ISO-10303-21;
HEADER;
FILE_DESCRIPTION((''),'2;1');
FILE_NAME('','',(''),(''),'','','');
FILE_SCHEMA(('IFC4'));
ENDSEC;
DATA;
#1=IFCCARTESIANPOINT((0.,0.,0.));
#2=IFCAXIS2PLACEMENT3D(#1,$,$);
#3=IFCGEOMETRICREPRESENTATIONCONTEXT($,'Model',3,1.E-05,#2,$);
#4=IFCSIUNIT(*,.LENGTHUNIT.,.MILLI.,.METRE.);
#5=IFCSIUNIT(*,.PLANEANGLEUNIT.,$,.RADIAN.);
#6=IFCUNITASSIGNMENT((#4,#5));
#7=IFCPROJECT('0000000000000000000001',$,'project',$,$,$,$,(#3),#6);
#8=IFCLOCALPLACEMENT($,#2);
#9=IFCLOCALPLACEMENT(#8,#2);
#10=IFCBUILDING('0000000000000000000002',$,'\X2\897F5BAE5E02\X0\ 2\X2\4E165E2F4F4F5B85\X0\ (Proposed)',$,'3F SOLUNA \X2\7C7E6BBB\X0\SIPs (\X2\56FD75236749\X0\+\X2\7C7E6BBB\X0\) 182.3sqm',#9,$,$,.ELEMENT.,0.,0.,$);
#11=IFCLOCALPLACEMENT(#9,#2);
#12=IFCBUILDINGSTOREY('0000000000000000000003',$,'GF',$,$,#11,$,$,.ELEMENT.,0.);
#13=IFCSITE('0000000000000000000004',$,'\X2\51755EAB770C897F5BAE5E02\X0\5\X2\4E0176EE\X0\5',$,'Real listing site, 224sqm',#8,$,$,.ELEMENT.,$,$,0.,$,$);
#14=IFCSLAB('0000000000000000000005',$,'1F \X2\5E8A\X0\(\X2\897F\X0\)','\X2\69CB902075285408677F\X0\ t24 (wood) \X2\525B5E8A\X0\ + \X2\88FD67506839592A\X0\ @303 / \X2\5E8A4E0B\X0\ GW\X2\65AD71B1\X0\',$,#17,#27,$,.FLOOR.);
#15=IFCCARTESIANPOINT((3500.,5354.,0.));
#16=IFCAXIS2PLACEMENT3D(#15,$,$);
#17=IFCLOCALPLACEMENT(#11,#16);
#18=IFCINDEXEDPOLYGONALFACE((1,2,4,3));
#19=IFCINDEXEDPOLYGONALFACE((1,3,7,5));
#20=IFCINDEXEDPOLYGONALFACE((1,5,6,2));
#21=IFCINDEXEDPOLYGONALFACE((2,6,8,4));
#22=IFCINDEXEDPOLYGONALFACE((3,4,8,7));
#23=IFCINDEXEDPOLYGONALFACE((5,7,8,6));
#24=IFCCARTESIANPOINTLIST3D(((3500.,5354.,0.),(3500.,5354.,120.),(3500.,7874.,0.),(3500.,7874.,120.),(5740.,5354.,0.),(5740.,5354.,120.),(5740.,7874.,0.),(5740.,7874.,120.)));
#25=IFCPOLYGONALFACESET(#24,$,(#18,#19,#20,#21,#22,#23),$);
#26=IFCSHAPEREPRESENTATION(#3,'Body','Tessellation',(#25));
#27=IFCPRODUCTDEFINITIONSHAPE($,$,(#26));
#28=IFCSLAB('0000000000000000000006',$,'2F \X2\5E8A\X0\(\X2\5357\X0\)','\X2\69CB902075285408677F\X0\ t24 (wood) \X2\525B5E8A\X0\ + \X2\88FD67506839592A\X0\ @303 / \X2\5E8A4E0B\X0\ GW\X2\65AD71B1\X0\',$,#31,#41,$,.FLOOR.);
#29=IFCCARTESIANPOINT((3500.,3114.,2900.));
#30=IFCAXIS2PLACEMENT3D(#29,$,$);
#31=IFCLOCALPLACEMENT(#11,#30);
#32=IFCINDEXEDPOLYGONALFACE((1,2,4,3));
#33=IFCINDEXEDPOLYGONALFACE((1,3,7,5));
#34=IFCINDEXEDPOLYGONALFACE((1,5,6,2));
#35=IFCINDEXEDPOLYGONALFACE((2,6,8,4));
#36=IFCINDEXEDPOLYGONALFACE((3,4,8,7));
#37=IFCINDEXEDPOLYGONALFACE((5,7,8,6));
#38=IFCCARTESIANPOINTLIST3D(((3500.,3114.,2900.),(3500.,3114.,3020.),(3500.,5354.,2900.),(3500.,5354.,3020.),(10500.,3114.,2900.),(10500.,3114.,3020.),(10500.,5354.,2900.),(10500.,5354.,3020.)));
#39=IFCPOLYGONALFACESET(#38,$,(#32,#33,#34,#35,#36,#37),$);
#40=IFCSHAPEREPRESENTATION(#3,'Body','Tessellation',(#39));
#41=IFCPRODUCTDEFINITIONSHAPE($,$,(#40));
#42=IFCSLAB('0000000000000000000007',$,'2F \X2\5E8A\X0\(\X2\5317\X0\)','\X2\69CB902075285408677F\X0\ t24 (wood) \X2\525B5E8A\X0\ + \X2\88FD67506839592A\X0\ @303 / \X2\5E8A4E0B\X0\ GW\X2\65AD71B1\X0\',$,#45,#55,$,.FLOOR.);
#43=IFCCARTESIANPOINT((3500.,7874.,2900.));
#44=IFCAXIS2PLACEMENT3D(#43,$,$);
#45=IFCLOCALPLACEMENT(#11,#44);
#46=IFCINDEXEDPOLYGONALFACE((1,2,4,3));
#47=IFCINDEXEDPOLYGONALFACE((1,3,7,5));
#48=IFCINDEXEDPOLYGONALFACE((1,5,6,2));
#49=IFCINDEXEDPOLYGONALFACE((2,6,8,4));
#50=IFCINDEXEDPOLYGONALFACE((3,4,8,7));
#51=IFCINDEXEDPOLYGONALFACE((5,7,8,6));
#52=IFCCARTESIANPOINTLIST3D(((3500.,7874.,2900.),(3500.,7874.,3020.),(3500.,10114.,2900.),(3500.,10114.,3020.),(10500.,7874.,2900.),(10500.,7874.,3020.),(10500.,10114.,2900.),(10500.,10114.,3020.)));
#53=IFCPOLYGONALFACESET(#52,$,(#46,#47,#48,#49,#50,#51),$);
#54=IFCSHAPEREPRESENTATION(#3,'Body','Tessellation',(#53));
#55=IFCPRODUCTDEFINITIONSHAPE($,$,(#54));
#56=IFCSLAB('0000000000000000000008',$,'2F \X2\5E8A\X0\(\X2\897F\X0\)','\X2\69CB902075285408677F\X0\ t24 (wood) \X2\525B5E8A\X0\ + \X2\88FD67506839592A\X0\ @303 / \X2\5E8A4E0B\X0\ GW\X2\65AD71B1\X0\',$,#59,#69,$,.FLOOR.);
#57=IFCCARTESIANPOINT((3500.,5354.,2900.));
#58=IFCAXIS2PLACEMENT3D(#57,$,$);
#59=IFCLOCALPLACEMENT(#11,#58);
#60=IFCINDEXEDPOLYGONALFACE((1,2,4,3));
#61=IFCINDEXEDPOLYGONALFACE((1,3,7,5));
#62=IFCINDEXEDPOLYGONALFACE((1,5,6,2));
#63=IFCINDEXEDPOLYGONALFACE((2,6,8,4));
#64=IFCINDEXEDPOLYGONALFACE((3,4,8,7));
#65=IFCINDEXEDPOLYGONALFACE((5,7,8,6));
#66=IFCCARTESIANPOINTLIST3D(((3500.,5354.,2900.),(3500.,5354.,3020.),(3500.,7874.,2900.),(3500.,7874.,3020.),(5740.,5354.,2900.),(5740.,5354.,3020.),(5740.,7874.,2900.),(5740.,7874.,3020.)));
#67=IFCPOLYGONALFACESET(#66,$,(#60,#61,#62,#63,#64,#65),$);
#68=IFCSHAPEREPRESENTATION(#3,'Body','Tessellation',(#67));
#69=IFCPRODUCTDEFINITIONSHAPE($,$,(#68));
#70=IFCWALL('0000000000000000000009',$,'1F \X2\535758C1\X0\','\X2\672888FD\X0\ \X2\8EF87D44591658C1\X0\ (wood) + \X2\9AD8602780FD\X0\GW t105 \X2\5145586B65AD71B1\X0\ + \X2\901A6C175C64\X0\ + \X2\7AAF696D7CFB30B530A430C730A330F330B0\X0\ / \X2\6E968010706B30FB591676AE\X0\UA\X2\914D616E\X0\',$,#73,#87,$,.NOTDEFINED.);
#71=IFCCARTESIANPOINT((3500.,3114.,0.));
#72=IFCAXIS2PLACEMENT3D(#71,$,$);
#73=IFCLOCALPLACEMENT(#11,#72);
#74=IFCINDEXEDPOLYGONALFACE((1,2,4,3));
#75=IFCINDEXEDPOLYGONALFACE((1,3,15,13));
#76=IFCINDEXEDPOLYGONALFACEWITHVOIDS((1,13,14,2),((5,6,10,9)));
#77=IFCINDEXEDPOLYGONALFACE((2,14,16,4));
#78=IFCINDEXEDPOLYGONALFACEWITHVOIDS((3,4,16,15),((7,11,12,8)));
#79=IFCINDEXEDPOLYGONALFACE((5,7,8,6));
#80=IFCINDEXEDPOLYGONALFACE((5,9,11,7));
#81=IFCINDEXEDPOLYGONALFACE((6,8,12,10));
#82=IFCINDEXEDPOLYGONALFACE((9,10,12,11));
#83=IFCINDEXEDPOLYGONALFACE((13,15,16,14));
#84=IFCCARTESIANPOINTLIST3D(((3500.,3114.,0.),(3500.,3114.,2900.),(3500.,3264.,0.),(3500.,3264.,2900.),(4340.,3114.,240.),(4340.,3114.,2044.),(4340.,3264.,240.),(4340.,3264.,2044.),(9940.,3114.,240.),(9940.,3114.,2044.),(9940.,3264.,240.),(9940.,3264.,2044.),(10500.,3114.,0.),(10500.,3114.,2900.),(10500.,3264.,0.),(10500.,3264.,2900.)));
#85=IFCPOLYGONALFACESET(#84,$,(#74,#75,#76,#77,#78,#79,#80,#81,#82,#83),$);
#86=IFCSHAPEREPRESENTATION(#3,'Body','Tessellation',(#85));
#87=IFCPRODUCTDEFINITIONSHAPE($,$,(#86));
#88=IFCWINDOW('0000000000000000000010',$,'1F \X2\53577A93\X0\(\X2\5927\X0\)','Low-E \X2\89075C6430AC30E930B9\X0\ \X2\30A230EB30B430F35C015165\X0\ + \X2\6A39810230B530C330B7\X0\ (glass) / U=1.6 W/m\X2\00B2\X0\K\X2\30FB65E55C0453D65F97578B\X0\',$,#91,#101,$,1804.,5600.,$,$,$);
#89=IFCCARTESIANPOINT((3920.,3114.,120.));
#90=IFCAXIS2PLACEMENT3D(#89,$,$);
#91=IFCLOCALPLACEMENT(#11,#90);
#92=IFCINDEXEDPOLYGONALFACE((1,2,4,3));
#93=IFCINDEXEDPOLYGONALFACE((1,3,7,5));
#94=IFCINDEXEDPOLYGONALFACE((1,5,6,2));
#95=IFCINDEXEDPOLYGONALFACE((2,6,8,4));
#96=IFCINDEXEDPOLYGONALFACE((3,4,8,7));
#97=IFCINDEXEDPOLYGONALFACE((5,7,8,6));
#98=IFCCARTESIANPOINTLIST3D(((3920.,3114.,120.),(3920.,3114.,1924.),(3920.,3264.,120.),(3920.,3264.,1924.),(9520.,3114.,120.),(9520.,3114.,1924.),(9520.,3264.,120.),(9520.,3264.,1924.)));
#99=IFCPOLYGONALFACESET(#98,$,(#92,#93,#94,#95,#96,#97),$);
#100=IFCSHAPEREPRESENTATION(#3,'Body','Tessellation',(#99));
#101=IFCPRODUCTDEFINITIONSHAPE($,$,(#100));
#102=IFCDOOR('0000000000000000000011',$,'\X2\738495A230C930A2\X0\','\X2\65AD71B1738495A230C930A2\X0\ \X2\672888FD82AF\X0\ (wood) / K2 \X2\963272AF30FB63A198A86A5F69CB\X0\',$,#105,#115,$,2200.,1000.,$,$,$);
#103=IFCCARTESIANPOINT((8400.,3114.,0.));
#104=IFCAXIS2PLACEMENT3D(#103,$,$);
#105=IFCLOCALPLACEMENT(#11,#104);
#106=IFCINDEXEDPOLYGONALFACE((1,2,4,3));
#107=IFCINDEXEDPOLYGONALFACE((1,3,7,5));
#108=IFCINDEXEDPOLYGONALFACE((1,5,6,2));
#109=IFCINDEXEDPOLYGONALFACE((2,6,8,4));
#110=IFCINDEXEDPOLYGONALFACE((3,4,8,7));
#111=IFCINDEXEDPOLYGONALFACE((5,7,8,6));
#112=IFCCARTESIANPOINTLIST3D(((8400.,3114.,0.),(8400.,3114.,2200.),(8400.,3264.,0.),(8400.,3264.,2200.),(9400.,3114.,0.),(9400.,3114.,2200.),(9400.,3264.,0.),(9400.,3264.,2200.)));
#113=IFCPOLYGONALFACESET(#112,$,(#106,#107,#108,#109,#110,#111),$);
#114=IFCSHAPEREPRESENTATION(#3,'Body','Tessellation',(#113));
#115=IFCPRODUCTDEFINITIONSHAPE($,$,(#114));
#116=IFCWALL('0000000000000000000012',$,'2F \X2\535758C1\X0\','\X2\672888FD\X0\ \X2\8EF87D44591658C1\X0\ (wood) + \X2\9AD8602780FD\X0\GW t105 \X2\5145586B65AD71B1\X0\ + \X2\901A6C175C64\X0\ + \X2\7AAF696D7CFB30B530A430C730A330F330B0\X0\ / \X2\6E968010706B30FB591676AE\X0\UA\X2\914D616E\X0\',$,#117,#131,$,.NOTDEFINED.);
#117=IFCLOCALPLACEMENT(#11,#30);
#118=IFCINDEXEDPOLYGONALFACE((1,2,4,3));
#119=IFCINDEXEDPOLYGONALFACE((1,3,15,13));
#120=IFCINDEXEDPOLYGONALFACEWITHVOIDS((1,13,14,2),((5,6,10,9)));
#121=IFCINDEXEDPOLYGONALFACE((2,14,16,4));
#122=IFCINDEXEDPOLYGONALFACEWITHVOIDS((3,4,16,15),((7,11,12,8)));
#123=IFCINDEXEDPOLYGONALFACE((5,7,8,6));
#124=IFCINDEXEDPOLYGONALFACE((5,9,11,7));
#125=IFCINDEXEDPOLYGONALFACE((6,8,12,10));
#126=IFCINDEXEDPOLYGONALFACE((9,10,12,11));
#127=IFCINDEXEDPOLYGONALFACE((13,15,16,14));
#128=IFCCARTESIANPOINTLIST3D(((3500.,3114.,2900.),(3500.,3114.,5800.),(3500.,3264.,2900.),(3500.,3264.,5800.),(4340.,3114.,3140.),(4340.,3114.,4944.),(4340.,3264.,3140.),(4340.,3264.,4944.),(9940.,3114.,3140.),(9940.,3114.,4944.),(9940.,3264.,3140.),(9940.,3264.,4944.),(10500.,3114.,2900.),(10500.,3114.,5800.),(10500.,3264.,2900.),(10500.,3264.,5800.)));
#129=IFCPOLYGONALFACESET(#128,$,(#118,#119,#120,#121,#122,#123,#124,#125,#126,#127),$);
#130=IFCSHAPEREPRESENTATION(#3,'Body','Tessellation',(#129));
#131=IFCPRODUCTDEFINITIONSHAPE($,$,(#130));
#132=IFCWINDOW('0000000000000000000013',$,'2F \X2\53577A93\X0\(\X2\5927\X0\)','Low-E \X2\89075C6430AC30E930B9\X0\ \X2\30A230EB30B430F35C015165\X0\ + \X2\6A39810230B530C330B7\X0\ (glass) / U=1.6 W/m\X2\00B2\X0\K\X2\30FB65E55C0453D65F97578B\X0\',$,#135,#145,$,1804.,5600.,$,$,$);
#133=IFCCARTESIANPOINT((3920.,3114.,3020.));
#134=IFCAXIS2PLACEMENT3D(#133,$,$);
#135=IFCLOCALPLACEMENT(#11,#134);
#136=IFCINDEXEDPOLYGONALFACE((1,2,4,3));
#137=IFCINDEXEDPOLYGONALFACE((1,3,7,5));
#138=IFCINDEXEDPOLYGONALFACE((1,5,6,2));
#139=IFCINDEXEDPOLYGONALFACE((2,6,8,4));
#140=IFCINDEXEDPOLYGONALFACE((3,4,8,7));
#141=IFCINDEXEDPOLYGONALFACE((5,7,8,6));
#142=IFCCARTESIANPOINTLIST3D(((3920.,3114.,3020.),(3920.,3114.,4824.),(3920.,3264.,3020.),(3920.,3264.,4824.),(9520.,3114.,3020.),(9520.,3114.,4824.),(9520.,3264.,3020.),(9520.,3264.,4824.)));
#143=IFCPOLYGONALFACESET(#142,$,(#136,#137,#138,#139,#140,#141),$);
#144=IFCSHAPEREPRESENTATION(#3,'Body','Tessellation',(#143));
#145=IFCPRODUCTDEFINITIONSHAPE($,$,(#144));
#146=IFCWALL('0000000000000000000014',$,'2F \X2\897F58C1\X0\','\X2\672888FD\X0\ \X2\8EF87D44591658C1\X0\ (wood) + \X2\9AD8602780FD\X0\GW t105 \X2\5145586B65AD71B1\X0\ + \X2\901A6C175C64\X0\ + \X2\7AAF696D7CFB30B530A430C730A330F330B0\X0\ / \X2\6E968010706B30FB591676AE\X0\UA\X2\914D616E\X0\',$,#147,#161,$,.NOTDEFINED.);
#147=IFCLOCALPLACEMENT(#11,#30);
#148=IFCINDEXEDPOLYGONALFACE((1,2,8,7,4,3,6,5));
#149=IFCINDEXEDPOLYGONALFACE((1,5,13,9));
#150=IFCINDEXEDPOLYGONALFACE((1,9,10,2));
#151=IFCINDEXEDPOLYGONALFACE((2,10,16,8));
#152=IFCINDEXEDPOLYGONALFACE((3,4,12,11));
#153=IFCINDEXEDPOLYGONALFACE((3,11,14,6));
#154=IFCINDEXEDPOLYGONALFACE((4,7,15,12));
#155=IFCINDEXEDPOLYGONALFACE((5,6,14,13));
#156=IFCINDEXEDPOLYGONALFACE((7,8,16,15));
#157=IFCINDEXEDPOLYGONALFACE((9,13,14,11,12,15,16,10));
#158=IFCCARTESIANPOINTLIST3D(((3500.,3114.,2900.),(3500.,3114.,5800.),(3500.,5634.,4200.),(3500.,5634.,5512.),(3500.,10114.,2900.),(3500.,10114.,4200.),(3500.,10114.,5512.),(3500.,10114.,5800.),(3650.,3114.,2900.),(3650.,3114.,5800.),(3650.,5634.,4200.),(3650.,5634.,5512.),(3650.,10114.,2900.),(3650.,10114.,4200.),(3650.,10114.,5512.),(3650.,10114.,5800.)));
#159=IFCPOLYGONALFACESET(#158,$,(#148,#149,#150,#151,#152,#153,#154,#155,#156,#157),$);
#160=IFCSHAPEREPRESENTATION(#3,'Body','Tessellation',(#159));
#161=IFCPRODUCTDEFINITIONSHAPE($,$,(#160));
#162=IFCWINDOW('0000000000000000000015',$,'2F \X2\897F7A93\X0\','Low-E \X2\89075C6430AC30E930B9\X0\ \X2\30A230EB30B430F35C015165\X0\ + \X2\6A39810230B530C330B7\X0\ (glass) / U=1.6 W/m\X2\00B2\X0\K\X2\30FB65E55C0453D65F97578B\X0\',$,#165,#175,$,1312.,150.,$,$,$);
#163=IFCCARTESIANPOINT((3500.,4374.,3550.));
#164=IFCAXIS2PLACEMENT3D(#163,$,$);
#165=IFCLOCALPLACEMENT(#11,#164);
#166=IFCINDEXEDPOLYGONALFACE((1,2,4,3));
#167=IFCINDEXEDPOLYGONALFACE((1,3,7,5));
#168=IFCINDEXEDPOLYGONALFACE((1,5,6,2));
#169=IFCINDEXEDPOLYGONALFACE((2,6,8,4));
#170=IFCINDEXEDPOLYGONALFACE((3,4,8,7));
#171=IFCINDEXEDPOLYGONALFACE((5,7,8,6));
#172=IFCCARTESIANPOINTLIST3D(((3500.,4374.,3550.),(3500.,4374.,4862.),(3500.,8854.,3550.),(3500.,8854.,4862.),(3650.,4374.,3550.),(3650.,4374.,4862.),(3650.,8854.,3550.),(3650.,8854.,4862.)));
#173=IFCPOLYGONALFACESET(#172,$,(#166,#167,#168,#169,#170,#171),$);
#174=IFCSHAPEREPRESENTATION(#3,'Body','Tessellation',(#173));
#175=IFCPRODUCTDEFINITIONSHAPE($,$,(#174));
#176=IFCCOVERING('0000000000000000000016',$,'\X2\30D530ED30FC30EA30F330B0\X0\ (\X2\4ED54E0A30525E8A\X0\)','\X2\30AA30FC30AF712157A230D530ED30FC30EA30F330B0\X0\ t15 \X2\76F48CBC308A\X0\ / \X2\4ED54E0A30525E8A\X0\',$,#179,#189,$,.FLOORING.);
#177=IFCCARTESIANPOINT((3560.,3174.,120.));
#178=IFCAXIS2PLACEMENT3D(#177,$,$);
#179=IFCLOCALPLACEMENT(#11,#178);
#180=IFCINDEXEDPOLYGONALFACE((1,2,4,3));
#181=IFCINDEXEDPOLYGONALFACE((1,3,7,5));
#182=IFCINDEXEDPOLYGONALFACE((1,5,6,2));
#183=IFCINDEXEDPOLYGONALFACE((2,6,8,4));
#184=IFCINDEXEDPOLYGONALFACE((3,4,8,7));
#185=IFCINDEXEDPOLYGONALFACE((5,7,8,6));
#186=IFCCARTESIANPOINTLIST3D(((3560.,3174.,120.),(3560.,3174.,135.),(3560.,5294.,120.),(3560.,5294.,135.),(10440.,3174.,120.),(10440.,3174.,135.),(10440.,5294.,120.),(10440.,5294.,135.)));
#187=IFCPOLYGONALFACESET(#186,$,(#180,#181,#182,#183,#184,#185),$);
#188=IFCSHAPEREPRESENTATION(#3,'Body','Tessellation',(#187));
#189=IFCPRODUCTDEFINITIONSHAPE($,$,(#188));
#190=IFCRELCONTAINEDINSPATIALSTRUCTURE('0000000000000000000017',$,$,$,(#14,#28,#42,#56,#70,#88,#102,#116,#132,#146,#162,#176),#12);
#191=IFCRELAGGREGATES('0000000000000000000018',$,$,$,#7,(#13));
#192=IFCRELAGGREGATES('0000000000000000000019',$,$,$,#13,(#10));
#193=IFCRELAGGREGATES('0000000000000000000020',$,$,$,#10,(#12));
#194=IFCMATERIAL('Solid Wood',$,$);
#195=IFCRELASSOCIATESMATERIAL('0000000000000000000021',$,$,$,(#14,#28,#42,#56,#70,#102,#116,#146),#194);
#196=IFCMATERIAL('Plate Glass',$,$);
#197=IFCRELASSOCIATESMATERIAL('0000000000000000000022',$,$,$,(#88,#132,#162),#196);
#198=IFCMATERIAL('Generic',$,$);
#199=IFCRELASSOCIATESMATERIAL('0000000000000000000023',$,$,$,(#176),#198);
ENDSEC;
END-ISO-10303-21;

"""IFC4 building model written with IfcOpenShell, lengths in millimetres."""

from ifc_helpers import new_model, si_unit, frame, frame_2d, origin, place, context, project, spatial, rectangle, extrude, material, element, fill, save


model = new_model("IFC4")

# Units and contexts
model_context = context("Model", 3, precision=1e-05, world=origin())
ifc_project = project(units=[si_unit("LENGTHUNIT", "METRE", prefix="MILLI"), si_unit("PLANEANGLEUNIT", "RADIAN")], contexts=[model_context])

# Site, building, storey
site_placement = place(None, origin())
site = spatial("IfcSite", under=ifc_project, at=site_placement, Name="兵庫県西宮市5丁目5", ObjectType="Real listing site, 224sqm", CompositionType="ELEMENT", RefElevation=0.0)
building_placement = place(site_placement, origin())
building = spatial("IfcBuilding", under=site, at=building_placement, Name="西宮市 2世帯住宅 (Proposed)", ObjectType="3F SOLUNA 籾殻SIPs (国産杉+籾殻) 182.3sqm", CompositionType="ELEMENT", ElevationOfRefHeight=0.0, ElevationOfTerrain=0.0)
storey_placement = place(building_placement, origin())
storey = spatial("IfcBuildingStorey", under=building, at=storey_placement, Name="GF", CompositionType="ELEMENT", Elevation=0.0)

# Slabs
ifc_material_1 = material(Name="Solid Wood")
slab_1_placement = place(storey_placement, frame((3500.0, 5354.0, 0.0)))
element("IfcSlab", 1, at=slab_1_placement, inside=storey, material=ifc_material_1, Name="1F 床(西)", Description="構造用合板 t24 (wood) 剛床 + 製材根太 @303 / 床下 GW断熱", PredefinedType="FLOOR", context=model_context, shape_type="SweptSolid", body=[
    extrude(rectangle(XDim=2240.0, YDim=2520.0, at=frame_2d((1120.0, 1260.0))), frame((3500.0, 5354.0, 0.0)), (0.0, 0.0, 1.0), 120.0),
])
slab_2_placement = place(storey_placement, frame((3500.0, 3114.0, 2900.0)))
element("IfcSlab", 2, at=slab_2_placement, inside=storey, material=ifc_material_1, Name="2F 床(南)", Description="構造用合板 t24 (wood) 剛床 + 製材根太 @303 / 床下 GW断熱", PredefinedType="FLOOR", context=model_context, shape_type="SweptSolid", body=[
    extrude(rectangle(XDim=7000.0, YDim=2240.0, at=frame_2d((3500.0, 1120.0))), frame((3500.0, 3114.0, 2900.0)), (0.0, 0.0, 1.0), 120.0),
])
slab_3_placement = place(storey_placement, frame((3500.0, 7874.0, 2900.0)))
element("IfcSlab", 3, at=slab_3_placement, inside=storey, material=ifc_material_1, Name="2F 床(北)", Description="構造用合板 t24 (wood) 剛床 + 製材根太 @303 / 床下 GW断熱", PredefinedType="FLOOR", context=model_context, shape_type="SweptSolid", body=[
    extrude(rectangle(XDim=7000.0, YDim=2240.0, at=frame_2d((3500.0, 1120.0))), frame((3500.0, 7874.0, 2900.0)), (0.0, 0.0, 1.0), 120.0),
])
slab_4_placement = place(storey_placement, frame((3500.0, 5354.0, 2900.0)))
element("IfcSlab", 4, at=slab_4_placement, inside=storey, material=ifc_material_1, Name="2F 床(西)", Description="構造用合板 t24 (wood) 剛床 + 製材根太 @303 / 床下 GW断熱", PredefinedType="FLOOR", context=model_context, shape_type="SweptSolid", body=[
    extrude(rectangle(XDim=2240.0, YDim=2520.0, at=frame_2d((1120.0, 1260.0))), frame((3500.0, 5354.0, 2900.0)), (0.0, 0.0, 1.0), 120.0),
])

# Wall, openings, window, door
wall_1_placement = place(storey_placement, frame((3500.0, 3114.0, 0.0)))
wall_1 = element("IfcWall", 5, at=wall_1_placement, inside=storey, material=ifc_material_1, Name="1F 南壁", Description="木製 軸組外壁 (wood) + 高性能GW t105 充填断熱 + 通気層 + 窯業系サイディング / 準耐火・外皮UA配慮", PredefinedType="NOTDEFINED", context=model_context, shape_type="SweptSolid", body=[
    extrude(rectangle(XDim=7000.0, YDim=150.0, at=frame_2d((3500.0, 75.0))), frame((3500.0, 3114.0, 0.0)), (0.0, 0.0, 1.0), 2900.0),
])
opening_1_placement = place(storey_placement, frame((3920.0, 3114.0, 120.0)))
opening_1 = element("IfcOpeningElement", 6, at=opening_1_placement, cuts=wall_1, PredefinedType="NOTDEFINED", context=model_context, shape_type="SweptSolid", body=[
    extrude(rectangle(XDim=5600.0, YDim=150.0, at=frame_2d((2800.0, 75.0))), frame((3920.0, 3114.0, 120.0)), (0.0, 0.0, 1.0), 1804.0),
])
opening_2_placement = place(storey_placement, frame((8400.0, 3114.0, 0.0)))
opening_2 = element("IfcOpeningElement", 7, at=opening_2_placement, cuts=wall_1, PredefinedType="NOTDEFINED", context=model_context, shape_type="SweptSolid", body=[
    extrude(rectangle(XDim=1000.0, YDim=150.0, at=frame_2d((500.0, 75.0))), frame((8400.0, 3114.0, 0.0)), (0.0, 0.0, 1.0), 2200.0),
])
ifc_material_2 = material(Name="Plate Glass")
window_1_placement = place(storey_placement, frame((3920.0, 3114.0, 120.0)))
window_1 = element("IfcWindow", 8, at=window_1_placement, inside=storey, material=ifc_material_2, Name="1F 南窓(大)", Description="Low-E 複層ガラス アルゴン封入 + 樹脂サッシ (glass) / U=1.6 W/m²K・日射取得型", OverallHeight=1804.0, OverallWidth=5600.0, context=model_context, shape_type="SweptSolid", body=[
    extrude(rectangle(XDim=5600.0, YDim=150.0, at=frame_2d((2800.0, 75.0))), frame((3920.0, 3114.0, 120.0)), (0.0, 0.0, 1.0), 1804.0),
])
fill(opening_1, window_1)
door_placement = place(storey_placement, frame((8400.0, 3114.0, 0.0)))
door = element("IfcDoor", 9, at=door_placement, inside=storey, material=ifc_material_1, Name="玄関ドア", Description="断熱玄関ドア 木製芯 (wood) / K2 防犯・採風機構", OverallHeight=2200.0, OverallWidth=1000.0, context=model_context, shape_type="SweptSolid", body=[
    extrude(rectangle(XDim=1000.0, YDim=150.0, at=frame_2d((500.0, 75.0))), frame((8400.0, 3114.0, 0.0)), (0.0, 0.0, 1.0), 2200.0),
])
fill(opening_2, door)

# Wall, opening, window
wall_2_placement = place(storey_placement, frame((3500.0, 3114.0, 2900.0)))
wall_2 = element("IfcWall", 10, at=wall_2_placement, inside=storey, material=ifc_material_1, Name="2F 南壁", Description="木製 軸組外壁 (wood) + 高性能GW t105 充填断熱 + 通気層 + 窯業系サイディング / 準耐火・外皮UA配慮", PredefinedType="NOTDEFINED", context=model_context, shape_type="SweptSolid", body=[
    extrude(rectangle(XDim=7000.0, YDim=150.0, at=frame_2d((3500.0, 75.0))), frame((3500.0, 3114.0, 2900.0)), (0.0, 0.0, 1.0), 2900.0),
])
opening_3_placement = place(storey_placement, frame((3920.0, 3114.0, 3020.0)))
opening_3 = element("IfcOpeningElement", 11, at=opening_3_placement, cuts=wall_2, PredefinedType="NOTDEFINED", context=model_context, shape_type="SweptSolid", body=[
    extrude(rectangle(XDim=5600.0, YDim=150.0, at=frame_2d((2800.0, 75.0))), frame((3920.0, 3114.0, 3020.0)), (0.0, 0.0, 1.0), 1804.0),
])
window_2_placement = place(storey_placement, frame((3920.0, 3114.0, 3020.0)))
window_2 = element("IfcWindow", 12, at=window_2_placement, inside=storey, material=ifc_material_2, Name="2F 南窓(大)", Description="Low-E 複層ガラス アルゴン封入 + 樹脂サッシ (glass) / U=1.6 W/m²K・日射取得型", OverallHeight=1804.0, OverallWidth=5600.0, context=model_context, shape_type="SweptSolid", body=[
    extrude(rectangle(XDim=5600.0, YDim=150.0, at=frame_2d((2800.0, 75.0))), frame((3920.0, 3114.0, 3020.0)), (0.0, 0.0, 1.0), 1804.0),
])
fill(opening_3, window_2)

# Wall, opening, window
wall_3_placement = place(storey_placement, frame((3500.0, 3114.0, 2900.0)))
wall_3 = element("IfcWall", 13, at=wall_3_placement, inside=storey, material=ifc_material_1, Name="2F 西壁", Description="木製 軸組外壁 (wood) + 高性能GW t105 充填断熱 + 通気層 + 窯業系サイディング / 準耐火・外皮UA配慮", PredefinedType="NOTDEFINED", context=model_context, shape_type="SweptSolid", body=[
    extrude(rectangle(XDim=150.0, YDim=7000.0, at=frame_2d((75.0, 3500.0))), frame((3500.0, 3114.0, 2900.0)), (0.0, 0.0, 1.0), 2900.0),
])
opening_4_placement = place(storey_placement, frame((3500.0, 4374.0, 3550.0)))
opening_4 = element("IfcOpeningElement", 14, at=opening_4_placement, cuts=wall_3, PredefinedType="NOTDEFINED", context=model_context, shape_type="SweptSolid", body=[
    extrude(rectangle(XDim=150.0, YDim=4480.0, at=frame_2d((75.0, 2240.0))), frame((3500.0, 4374.0, 3550.0)), (0.0, 0.0, 1.0), 1312.0),
])
window_3_placement = place(storey_placement, frame((3500.0, 4374.0, 3550.0)))
window_3 = element("IfcWindow", 15, at=window_3_placement, inside=storey, material=ifc_material_2, Name="2F 西窓", Description="Low-E 複層ガラス アルゴン封入 + 樹脂サッシ (glass) / U=1.6 W/m²K・日射取得型", OverallHeight=1312.0, OverallWidth=150.0, context=model_context, shape_type="SweptSolid", body=[
    extrude(rectangle(XDim=150.0, YDim=4480.0, at=frame_2d((75.0, 2240.0))), frame((3500.0, 4374.0, 3550.0)), (0.0, 0.0, 1.0), 1312.0),
])
fill(opening_4, window_3)

# Covering
ifc_material_3 = material(Name="Generic")
covering_1_placement = place(storey_placement, frame((3560.0, 3174.0, 120.0)))
element("IfcCovering", 16, at=covering_1_placement, inside=storey, material=ifc_material_3, Name="フローリング (仕上げ床)", Description="オーク無垢フローリング t15 直貼り / 仕上げ床", PredefinedType="FLOORING", context=model_context, shape_type="SweptSolid", body=[
    extrude(rectangle(XDim=6880.0, YDim=2120.0, at=frame_2d((3440.0, 1060.0))), frame((3560.0, 3174.0, 120.0)), (0.0, 0.0, 1.0), 15.0),
])

save(model, "model.ifc")
